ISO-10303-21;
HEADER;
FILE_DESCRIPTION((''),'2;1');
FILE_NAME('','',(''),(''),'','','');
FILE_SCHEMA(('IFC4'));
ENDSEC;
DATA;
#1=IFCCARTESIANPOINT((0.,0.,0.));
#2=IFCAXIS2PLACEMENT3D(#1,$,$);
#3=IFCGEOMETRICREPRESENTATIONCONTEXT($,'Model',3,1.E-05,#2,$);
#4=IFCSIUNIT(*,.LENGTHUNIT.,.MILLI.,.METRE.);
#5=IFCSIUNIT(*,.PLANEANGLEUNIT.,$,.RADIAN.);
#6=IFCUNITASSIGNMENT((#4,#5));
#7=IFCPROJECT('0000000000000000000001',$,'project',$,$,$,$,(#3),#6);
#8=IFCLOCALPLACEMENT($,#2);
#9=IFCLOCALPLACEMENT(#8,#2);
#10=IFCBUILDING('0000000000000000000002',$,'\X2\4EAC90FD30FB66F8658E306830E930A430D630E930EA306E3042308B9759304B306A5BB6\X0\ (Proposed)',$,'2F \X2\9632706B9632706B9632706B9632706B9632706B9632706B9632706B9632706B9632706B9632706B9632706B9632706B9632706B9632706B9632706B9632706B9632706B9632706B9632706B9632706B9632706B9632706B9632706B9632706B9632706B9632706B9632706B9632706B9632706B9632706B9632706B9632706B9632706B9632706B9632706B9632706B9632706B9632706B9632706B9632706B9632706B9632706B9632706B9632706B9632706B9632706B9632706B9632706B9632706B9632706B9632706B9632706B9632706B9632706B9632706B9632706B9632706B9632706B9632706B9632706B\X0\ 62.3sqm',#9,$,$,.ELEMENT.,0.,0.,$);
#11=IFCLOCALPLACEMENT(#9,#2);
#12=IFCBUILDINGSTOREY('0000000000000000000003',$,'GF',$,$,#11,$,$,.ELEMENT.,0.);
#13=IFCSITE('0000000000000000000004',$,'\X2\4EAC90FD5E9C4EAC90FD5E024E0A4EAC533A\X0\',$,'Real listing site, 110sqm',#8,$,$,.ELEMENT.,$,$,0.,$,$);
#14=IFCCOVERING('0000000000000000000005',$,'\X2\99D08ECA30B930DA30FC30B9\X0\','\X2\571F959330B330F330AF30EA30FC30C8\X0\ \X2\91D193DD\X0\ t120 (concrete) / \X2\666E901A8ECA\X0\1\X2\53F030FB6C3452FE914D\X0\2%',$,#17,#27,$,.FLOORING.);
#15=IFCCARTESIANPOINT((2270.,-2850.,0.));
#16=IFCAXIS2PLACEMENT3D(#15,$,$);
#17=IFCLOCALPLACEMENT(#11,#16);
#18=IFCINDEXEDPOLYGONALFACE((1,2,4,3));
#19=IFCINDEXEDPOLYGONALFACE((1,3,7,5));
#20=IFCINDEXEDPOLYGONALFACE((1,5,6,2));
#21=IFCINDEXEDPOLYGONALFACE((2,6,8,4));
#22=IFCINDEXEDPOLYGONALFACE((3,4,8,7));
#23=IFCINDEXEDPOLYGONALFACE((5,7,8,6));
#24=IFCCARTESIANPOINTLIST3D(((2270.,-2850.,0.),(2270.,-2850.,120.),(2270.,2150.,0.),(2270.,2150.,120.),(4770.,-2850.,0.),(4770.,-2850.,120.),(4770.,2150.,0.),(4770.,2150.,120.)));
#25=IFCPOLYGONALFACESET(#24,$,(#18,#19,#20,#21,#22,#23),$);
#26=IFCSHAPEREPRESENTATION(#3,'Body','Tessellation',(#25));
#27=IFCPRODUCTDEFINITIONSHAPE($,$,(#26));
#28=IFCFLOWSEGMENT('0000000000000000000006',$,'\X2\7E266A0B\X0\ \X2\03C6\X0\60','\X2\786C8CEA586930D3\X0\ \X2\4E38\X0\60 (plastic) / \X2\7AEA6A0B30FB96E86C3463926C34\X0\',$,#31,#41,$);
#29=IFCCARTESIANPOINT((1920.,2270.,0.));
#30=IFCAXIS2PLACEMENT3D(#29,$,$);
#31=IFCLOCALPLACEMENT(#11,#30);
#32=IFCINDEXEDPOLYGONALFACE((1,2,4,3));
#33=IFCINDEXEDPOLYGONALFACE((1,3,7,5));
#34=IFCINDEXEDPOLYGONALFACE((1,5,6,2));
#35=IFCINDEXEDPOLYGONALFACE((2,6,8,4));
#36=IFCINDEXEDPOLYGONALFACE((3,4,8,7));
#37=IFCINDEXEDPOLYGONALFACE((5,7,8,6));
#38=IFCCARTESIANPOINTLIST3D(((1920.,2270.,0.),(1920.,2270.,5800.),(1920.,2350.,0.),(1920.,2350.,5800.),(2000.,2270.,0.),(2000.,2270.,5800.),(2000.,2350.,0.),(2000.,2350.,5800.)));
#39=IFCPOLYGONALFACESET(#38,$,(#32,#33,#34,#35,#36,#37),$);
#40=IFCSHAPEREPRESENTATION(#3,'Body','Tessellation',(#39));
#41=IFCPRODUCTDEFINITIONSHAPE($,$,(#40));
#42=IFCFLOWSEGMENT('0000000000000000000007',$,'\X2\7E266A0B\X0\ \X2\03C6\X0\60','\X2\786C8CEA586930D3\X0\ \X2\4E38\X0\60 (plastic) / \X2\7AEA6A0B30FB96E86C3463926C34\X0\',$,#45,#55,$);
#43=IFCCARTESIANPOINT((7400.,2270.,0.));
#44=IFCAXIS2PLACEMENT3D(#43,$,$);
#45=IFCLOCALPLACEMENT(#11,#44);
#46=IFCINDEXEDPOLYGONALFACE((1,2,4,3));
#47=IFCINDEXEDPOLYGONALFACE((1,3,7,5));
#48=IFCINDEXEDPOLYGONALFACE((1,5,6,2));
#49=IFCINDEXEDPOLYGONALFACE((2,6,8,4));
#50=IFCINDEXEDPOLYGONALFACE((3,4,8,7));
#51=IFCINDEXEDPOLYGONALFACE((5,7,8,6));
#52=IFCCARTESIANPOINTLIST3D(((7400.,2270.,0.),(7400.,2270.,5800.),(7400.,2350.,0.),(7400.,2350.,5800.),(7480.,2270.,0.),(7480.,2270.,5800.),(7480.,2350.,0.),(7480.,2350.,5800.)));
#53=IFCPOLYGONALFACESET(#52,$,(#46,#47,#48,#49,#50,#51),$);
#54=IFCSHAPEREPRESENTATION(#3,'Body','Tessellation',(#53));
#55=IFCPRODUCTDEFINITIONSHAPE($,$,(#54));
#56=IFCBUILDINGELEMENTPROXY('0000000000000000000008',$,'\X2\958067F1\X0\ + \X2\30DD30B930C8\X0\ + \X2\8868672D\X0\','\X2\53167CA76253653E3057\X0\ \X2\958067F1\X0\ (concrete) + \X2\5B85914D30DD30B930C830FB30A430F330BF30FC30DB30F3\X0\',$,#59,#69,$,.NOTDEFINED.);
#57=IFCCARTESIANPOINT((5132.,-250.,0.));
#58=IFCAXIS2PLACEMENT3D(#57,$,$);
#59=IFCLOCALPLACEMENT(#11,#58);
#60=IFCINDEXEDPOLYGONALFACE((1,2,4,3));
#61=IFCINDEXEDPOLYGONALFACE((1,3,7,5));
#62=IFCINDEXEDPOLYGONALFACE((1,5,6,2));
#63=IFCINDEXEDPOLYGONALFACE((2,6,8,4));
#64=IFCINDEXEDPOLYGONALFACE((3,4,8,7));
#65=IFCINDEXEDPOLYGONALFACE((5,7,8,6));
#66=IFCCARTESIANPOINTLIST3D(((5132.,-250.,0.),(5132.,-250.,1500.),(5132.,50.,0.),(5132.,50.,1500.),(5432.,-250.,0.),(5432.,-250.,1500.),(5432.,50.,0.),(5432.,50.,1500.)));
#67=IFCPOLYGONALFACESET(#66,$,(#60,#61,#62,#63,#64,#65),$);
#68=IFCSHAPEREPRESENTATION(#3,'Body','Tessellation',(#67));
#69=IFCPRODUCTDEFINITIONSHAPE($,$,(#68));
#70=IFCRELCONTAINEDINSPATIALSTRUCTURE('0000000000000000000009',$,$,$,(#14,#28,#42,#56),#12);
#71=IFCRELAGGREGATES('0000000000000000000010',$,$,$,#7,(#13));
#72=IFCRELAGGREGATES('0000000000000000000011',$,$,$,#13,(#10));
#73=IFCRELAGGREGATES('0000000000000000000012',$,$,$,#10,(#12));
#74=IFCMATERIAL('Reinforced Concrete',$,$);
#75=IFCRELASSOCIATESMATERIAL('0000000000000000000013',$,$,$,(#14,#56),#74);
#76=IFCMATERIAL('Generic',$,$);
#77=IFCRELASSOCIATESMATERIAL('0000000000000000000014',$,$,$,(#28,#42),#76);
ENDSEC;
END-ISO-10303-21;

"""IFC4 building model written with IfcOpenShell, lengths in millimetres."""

from ifc_helpers import new_model, si_unit, frame, frame_2d, origin, place, context, project, spatial, rectangle, extrude, material, element, save


model = new_model("IFC4")

# Units and contexts
model_context = context("Model", 3, precision=1e-05, world=origin())
ifc_project = project(units=[si_unit("LENGTHUNIT", "METRE", prefix="MILLI"), si_unit("PLANEANGLEUNIT", "RADIAN")], contexts=[model_context])

# Site, building, storey
site_placement = place(None, origin())
site = spatial("IfcSite", under=ifc_project, at=site_placement, Name="京都府京都市上京区", ObjectType="Real listing site, 110sqm", CompositionType="ELEMENT", RefElevation=0.0)
building_placement = place(site_placement, origin())
building = spatial("IfcBuilding", under=site, at=building_placement, Name="京都・書斎とライブラリのある静かな家 (Proposed)", ObjectType="2F 防火防火防火防火防火防火防火防火防火防火防火防火防火防火防火防火防火防火防火防火防火防火防火防火防火防火防火防火防火防火防火防火防火防火防火防火防火防火防火防火防火防火防火防火防火防火防火防火防火防火防火防火防火防火防火防火防火防火防火防火 62.3sqm", CompositionType="ELEMENT", ElevationOfRefHeight=0.0, ElevationOfTerrain=0.0)
storey_placement = place(building_placement, origin())
storey = spatial("IfcBuildingStorey", under=building, at=storey_placement, Name="GF", CompositionType="ELEMENT", Elevation=0.0)

# Shared definitions
ifc_material_1 = material(Name="Reinforced Concrete")

# Covering
covering_1_placement = place(storey_placement, frame((2270.0, -2850.0, 0.0)))
element("IfcCovering", 1, at=covering_1_placement, inside=storey, material=ifc_material_1, Name="駐車スペース", Description="土間コンクリート 金鏝 t120 (concrete) / 普通車1台・水勾配2%", PredefinedType="FLOORING", context=model_context, shape_type="SweptSolid", body=[
    extrude(rectangle(XDim=2500.0, YDim=5000.0, at=frame_2d((1250.0, 2500.0))), frame((2270.0, -2850.0, 0.0)), (0.0, 0.0, 1.0), 120.0),
])

# Flow segments
ifc_material_2 = material(Name="Generic")
flow_segment_1_placement = place(storey_placement, frame((1920.0, 2270.0, 0.0)))
element("IfcFlowSegment", 2, at=flow_segment_1_placement, inside=storey, material=ifc_material_2, Name="縦樋 φ60", Description="硬質塩ビ 丸60 (plastic) / 竪樋・雨水排水", context=model_context, shape_type="SweptSolid", body=[
    extrude(rectangle(XDim=80.0, YDim=80.0, at=frame_2d((40.0, 40.0))), frame((1920.0, 2270.0, 0.0)), (0.0, 0.0, 1.0), 5800.0),
])
flow_segment_2_placement = place(storey_placement, frame((7400.0, 2270.0, 0.0)))
element("IfcFlowSegment", 3, at=flow_segment_2_placement, inside=storey, material=ifc_material_2, Name="縦樋 φ60", Description="硬質塩ビ 丸60 (plastic) / 竪樋・雨水排水", context=model_context, shape_type="SweptSolid", body=[
    extrude(rectangle(XDim=80.0, YDim=80.0, at=frame_2d((40.0, 40.0))), frame((7400.0, 2270.0, 0.0)), (0.0, 0.0, 1.0), 5800.0),
])

# Building element proxy
proxy_placement = place(storey_placement, frame((5132.0, -250.0, 0.0)))
element("IfcBuildingElementProxy", 4, at=proxy_placement, inside=storey, material=ifc_material_1, Name="門柱 + ポスト + 表札", Description="化粧打放し 門柱 (concrete) + 宅配ポスト・インターホン", PredefinedType="NOTDEFINED", context=model_context, shape_type="SweptSolid", body=[
    extrude(rectangle(XDim=300.0, YDim=300.0, at=frame_2d((150.0, 150.0))), frame((5132.0, -250.0, 0.0)), (0.0, 0.0, 1.0), 1500.0),
])

save(model, "model.ifc")
